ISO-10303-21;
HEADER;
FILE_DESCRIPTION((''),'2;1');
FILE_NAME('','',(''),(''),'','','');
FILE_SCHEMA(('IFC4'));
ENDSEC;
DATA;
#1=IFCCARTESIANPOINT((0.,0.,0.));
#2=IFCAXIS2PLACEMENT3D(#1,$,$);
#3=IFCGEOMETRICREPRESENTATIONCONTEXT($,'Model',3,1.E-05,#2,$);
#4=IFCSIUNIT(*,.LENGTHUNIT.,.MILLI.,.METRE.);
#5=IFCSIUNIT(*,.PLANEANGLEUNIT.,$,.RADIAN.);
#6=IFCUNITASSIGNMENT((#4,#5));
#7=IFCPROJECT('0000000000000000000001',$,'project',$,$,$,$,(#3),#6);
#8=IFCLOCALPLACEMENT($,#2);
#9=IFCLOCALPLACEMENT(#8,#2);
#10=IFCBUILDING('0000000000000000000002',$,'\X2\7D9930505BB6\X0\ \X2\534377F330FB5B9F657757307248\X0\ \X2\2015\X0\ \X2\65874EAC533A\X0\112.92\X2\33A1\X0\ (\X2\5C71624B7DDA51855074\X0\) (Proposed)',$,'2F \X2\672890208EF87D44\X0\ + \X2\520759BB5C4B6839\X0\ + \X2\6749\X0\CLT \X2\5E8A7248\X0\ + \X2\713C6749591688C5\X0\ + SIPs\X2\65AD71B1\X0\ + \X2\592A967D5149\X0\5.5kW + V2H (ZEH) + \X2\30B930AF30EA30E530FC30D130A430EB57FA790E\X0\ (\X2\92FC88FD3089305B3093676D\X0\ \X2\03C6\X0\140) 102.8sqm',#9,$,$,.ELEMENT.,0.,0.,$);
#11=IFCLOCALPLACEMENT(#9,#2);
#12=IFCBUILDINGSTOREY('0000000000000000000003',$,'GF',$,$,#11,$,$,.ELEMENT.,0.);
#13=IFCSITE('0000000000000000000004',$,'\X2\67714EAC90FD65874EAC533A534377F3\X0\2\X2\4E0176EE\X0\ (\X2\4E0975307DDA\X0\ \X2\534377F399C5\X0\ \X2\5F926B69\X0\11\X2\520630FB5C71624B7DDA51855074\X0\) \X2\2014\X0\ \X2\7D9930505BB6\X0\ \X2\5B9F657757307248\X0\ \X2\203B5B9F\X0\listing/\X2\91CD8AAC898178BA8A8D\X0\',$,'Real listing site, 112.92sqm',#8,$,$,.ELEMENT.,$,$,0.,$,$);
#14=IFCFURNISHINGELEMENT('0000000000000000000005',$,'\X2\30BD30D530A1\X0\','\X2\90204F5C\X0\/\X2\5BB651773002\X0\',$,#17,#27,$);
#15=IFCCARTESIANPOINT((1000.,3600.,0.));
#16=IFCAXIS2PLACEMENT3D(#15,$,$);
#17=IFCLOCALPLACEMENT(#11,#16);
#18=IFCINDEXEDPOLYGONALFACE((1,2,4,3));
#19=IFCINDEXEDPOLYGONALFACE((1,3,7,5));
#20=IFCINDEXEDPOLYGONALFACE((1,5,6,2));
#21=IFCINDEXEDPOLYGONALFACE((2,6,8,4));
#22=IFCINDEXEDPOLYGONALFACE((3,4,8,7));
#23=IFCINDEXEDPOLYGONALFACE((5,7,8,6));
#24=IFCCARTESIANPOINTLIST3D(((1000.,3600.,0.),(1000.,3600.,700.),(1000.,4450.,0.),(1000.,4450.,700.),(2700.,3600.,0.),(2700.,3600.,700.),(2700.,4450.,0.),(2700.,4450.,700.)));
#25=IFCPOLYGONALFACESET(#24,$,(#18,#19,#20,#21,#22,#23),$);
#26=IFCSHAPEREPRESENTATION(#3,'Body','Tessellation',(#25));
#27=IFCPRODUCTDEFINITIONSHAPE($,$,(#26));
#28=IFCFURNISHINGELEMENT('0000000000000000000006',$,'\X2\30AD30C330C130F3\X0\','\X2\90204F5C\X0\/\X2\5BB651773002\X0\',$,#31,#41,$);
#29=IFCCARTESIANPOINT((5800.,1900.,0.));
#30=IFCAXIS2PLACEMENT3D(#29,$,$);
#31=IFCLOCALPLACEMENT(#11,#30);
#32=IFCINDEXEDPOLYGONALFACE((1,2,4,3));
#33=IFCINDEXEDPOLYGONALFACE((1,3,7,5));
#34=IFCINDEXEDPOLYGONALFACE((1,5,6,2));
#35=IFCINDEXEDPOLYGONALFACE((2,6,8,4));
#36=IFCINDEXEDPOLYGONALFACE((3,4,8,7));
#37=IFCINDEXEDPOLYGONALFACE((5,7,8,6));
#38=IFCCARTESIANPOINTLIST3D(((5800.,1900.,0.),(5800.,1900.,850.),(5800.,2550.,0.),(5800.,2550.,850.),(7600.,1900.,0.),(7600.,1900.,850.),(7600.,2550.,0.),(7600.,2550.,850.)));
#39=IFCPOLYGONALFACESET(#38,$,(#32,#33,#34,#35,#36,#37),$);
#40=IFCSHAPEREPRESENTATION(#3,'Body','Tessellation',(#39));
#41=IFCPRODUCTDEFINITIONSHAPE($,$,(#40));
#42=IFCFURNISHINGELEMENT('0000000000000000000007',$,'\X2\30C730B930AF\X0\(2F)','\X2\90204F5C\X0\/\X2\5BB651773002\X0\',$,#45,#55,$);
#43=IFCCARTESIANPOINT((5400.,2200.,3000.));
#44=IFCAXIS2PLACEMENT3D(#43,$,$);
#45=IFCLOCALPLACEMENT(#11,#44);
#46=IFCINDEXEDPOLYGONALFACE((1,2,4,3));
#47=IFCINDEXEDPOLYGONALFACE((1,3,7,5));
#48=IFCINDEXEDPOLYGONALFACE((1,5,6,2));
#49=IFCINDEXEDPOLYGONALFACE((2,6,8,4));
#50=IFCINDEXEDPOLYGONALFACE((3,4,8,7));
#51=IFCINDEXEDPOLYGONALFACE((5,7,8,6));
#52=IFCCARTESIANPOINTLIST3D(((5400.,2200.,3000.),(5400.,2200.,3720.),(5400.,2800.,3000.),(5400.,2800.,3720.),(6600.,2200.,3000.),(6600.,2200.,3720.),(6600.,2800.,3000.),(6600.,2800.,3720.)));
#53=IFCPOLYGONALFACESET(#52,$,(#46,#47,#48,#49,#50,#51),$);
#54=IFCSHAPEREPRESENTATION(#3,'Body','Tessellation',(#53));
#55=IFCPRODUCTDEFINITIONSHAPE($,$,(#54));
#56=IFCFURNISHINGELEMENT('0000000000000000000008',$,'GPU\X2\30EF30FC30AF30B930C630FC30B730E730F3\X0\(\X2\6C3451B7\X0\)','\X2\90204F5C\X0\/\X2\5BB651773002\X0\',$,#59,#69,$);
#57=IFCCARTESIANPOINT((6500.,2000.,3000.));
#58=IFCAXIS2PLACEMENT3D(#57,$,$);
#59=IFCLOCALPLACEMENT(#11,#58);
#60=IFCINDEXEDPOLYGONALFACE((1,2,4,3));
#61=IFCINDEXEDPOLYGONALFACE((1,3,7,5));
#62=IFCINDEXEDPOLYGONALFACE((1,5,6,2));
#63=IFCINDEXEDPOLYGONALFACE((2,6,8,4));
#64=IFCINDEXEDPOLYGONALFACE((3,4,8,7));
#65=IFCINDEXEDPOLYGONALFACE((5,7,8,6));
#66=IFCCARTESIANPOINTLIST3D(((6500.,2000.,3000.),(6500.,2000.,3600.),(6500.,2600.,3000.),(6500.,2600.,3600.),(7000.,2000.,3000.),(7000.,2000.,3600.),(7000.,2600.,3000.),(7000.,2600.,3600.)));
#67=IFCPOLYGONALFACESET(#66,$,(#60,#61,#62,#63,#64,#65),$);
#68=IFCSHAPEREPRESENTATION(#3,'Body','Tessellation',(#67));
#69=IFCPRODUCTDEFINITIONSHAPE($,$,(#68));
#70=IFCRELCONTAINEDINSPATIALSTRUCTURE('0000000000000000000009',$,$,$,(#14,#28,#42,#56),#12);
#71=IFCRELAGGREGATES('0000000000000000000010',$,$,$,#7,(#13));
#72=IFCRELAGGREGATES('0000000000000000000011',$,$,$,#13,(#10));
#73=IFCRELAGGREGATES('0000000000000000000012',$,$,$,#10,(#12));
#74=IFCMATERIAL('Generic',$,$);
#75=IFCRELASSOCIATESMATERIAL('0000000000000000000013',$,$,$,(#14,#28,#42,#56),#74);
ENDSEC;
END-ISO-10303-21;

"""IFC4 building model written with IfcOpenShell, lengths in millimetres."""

from ifc_helpers import new_model, si_unit, frame, frame_2d, origin, place, context, project, spatial, rectangle, extrude, material, element, save


model = new_model("IFC4")

# Units and contexts
model_context = context("Model", 3, precision=1e-05, world=origin())
ifc_project = project(units=[si_unit("LENGTHUNIT", "METRE", prefix="MILLI"), si_unit("PLANEANGLEUNIT", "RADIAN")], contexts=[model_context])

# Site, building, storey
site_placement = place(None, origin())
site = spatial("IfcSite", under=ifc_project, at=site_placement, Name="東京都文京区千石2丁目 (三田線 千石駅 徒歩11分・山手線内側) — 継ぐ家 実敷地版 ※実listing/重説要確認", ObjectType="Real listing site, 112.92sqm", CompositionType="ELEMENT", RefElevation=0.0)
building_placement = place(site_placement, origin())
building = spatial("IfcBuilding", under=site, at=building_placement, Name="継ぐ家 千石・実敷地版 ― 文京区112.92㎡ (山手線内側) (Proposed)", ObjectType="2F 木造軸組 + 切妻屋根 + 杉CLT 床版 + 焼杉外装 + SIPs断熱 + 太陽光5.5kW + V2H (ZEH) + スクリューパイル基礎 (鋼製らせん杭 φ140) 102.8sqm", CompositionType="ELEMENT", ElevationOfRefHeight=0.0, ElevationOfTerrain=0.0)
storey_placement = place(building_placement, origin())
storey = spatial("IfcBuildingStorey", under=building, at=storey_placement, Name="GF", CompositionType="ELEMENT", Elevation=0.0)

# Shared definitions
ifc_material = material(Name="Generic")

# Furnishing elements
furnishing_1_placement = place(storey_placement, frame((1000.0, 3600.0, 0.0)))
element("IfcFurnishingElement", 1, at=furnishing_1_placement, inside=storey, material=ifc_material, Name="ソファ", Description="造作/家具。", context=model_context, shape_type="SweptSolid", body=[
    extrude(rectangle(XDim=1700.0, YDim=850.0, at=frame_2d((850.0, 425.0))), frame((1000.0, 3600.0, 0.0)), (0.0, 0.0, 1.0), 700.0),
])
furnishing_2_placement = place(storey_placement, frame((5800.0, 1900.0, 0.0)))
element("IfcFurnishingElement", 2, at=furnishing_2_placement, inside=storey, material=ifc_material, Name="キッチン", Description="造作/家具。", context=model_context, shape_type="SweptSolid", body=[
    extrude(rectangle(XDim=1800.0, YDim=650.0, at=frame_2d((900.0, 325.0))), frame((5800.0, 1900.0, 0.0)), (0.0, 0.0, 1.0), 850.0),
])
furnishing_3_placement = place(storey_placement, frame((5400.0, 2200.0, 3000.0)))
element("IfcFurnishingElement", 3, at=furnishing_3_placement, inside=storey, material=ifc_material, Name="デスク(2F)", Description="造作/家具。", context=model_context, shape_type="SweptSolid", body=[
    extrude(rectangle(XDim=1200.0, YDim=600.0, at=frame_2d((600.0, 300.0))), frame((5400.0, 2200.0, 3000.0)), (0.0, 0.0, 1.0), 720.0),
])
furnishing_4_placement = place(storey_placement, frame((6500.0, 2000.0, 3000.0)))
element("IfcFurnishingElement", 4, at=furnishing_4_placement, inside=storey, material=ifc_material, Name="GPUワークステーション(水冷)", Description="造作/家具。", context=model_context, shape_type="SweptSolid", body=[
    extrude(rectangle(XDim=500.0, YDim=600.0, at=frame_2d((250.0, 300.0))), frame((6500.0, 2000.0, 3000.0)), (0.0, 0.0, 1.0), 600.0),
])

save(model, "model.ifc")
